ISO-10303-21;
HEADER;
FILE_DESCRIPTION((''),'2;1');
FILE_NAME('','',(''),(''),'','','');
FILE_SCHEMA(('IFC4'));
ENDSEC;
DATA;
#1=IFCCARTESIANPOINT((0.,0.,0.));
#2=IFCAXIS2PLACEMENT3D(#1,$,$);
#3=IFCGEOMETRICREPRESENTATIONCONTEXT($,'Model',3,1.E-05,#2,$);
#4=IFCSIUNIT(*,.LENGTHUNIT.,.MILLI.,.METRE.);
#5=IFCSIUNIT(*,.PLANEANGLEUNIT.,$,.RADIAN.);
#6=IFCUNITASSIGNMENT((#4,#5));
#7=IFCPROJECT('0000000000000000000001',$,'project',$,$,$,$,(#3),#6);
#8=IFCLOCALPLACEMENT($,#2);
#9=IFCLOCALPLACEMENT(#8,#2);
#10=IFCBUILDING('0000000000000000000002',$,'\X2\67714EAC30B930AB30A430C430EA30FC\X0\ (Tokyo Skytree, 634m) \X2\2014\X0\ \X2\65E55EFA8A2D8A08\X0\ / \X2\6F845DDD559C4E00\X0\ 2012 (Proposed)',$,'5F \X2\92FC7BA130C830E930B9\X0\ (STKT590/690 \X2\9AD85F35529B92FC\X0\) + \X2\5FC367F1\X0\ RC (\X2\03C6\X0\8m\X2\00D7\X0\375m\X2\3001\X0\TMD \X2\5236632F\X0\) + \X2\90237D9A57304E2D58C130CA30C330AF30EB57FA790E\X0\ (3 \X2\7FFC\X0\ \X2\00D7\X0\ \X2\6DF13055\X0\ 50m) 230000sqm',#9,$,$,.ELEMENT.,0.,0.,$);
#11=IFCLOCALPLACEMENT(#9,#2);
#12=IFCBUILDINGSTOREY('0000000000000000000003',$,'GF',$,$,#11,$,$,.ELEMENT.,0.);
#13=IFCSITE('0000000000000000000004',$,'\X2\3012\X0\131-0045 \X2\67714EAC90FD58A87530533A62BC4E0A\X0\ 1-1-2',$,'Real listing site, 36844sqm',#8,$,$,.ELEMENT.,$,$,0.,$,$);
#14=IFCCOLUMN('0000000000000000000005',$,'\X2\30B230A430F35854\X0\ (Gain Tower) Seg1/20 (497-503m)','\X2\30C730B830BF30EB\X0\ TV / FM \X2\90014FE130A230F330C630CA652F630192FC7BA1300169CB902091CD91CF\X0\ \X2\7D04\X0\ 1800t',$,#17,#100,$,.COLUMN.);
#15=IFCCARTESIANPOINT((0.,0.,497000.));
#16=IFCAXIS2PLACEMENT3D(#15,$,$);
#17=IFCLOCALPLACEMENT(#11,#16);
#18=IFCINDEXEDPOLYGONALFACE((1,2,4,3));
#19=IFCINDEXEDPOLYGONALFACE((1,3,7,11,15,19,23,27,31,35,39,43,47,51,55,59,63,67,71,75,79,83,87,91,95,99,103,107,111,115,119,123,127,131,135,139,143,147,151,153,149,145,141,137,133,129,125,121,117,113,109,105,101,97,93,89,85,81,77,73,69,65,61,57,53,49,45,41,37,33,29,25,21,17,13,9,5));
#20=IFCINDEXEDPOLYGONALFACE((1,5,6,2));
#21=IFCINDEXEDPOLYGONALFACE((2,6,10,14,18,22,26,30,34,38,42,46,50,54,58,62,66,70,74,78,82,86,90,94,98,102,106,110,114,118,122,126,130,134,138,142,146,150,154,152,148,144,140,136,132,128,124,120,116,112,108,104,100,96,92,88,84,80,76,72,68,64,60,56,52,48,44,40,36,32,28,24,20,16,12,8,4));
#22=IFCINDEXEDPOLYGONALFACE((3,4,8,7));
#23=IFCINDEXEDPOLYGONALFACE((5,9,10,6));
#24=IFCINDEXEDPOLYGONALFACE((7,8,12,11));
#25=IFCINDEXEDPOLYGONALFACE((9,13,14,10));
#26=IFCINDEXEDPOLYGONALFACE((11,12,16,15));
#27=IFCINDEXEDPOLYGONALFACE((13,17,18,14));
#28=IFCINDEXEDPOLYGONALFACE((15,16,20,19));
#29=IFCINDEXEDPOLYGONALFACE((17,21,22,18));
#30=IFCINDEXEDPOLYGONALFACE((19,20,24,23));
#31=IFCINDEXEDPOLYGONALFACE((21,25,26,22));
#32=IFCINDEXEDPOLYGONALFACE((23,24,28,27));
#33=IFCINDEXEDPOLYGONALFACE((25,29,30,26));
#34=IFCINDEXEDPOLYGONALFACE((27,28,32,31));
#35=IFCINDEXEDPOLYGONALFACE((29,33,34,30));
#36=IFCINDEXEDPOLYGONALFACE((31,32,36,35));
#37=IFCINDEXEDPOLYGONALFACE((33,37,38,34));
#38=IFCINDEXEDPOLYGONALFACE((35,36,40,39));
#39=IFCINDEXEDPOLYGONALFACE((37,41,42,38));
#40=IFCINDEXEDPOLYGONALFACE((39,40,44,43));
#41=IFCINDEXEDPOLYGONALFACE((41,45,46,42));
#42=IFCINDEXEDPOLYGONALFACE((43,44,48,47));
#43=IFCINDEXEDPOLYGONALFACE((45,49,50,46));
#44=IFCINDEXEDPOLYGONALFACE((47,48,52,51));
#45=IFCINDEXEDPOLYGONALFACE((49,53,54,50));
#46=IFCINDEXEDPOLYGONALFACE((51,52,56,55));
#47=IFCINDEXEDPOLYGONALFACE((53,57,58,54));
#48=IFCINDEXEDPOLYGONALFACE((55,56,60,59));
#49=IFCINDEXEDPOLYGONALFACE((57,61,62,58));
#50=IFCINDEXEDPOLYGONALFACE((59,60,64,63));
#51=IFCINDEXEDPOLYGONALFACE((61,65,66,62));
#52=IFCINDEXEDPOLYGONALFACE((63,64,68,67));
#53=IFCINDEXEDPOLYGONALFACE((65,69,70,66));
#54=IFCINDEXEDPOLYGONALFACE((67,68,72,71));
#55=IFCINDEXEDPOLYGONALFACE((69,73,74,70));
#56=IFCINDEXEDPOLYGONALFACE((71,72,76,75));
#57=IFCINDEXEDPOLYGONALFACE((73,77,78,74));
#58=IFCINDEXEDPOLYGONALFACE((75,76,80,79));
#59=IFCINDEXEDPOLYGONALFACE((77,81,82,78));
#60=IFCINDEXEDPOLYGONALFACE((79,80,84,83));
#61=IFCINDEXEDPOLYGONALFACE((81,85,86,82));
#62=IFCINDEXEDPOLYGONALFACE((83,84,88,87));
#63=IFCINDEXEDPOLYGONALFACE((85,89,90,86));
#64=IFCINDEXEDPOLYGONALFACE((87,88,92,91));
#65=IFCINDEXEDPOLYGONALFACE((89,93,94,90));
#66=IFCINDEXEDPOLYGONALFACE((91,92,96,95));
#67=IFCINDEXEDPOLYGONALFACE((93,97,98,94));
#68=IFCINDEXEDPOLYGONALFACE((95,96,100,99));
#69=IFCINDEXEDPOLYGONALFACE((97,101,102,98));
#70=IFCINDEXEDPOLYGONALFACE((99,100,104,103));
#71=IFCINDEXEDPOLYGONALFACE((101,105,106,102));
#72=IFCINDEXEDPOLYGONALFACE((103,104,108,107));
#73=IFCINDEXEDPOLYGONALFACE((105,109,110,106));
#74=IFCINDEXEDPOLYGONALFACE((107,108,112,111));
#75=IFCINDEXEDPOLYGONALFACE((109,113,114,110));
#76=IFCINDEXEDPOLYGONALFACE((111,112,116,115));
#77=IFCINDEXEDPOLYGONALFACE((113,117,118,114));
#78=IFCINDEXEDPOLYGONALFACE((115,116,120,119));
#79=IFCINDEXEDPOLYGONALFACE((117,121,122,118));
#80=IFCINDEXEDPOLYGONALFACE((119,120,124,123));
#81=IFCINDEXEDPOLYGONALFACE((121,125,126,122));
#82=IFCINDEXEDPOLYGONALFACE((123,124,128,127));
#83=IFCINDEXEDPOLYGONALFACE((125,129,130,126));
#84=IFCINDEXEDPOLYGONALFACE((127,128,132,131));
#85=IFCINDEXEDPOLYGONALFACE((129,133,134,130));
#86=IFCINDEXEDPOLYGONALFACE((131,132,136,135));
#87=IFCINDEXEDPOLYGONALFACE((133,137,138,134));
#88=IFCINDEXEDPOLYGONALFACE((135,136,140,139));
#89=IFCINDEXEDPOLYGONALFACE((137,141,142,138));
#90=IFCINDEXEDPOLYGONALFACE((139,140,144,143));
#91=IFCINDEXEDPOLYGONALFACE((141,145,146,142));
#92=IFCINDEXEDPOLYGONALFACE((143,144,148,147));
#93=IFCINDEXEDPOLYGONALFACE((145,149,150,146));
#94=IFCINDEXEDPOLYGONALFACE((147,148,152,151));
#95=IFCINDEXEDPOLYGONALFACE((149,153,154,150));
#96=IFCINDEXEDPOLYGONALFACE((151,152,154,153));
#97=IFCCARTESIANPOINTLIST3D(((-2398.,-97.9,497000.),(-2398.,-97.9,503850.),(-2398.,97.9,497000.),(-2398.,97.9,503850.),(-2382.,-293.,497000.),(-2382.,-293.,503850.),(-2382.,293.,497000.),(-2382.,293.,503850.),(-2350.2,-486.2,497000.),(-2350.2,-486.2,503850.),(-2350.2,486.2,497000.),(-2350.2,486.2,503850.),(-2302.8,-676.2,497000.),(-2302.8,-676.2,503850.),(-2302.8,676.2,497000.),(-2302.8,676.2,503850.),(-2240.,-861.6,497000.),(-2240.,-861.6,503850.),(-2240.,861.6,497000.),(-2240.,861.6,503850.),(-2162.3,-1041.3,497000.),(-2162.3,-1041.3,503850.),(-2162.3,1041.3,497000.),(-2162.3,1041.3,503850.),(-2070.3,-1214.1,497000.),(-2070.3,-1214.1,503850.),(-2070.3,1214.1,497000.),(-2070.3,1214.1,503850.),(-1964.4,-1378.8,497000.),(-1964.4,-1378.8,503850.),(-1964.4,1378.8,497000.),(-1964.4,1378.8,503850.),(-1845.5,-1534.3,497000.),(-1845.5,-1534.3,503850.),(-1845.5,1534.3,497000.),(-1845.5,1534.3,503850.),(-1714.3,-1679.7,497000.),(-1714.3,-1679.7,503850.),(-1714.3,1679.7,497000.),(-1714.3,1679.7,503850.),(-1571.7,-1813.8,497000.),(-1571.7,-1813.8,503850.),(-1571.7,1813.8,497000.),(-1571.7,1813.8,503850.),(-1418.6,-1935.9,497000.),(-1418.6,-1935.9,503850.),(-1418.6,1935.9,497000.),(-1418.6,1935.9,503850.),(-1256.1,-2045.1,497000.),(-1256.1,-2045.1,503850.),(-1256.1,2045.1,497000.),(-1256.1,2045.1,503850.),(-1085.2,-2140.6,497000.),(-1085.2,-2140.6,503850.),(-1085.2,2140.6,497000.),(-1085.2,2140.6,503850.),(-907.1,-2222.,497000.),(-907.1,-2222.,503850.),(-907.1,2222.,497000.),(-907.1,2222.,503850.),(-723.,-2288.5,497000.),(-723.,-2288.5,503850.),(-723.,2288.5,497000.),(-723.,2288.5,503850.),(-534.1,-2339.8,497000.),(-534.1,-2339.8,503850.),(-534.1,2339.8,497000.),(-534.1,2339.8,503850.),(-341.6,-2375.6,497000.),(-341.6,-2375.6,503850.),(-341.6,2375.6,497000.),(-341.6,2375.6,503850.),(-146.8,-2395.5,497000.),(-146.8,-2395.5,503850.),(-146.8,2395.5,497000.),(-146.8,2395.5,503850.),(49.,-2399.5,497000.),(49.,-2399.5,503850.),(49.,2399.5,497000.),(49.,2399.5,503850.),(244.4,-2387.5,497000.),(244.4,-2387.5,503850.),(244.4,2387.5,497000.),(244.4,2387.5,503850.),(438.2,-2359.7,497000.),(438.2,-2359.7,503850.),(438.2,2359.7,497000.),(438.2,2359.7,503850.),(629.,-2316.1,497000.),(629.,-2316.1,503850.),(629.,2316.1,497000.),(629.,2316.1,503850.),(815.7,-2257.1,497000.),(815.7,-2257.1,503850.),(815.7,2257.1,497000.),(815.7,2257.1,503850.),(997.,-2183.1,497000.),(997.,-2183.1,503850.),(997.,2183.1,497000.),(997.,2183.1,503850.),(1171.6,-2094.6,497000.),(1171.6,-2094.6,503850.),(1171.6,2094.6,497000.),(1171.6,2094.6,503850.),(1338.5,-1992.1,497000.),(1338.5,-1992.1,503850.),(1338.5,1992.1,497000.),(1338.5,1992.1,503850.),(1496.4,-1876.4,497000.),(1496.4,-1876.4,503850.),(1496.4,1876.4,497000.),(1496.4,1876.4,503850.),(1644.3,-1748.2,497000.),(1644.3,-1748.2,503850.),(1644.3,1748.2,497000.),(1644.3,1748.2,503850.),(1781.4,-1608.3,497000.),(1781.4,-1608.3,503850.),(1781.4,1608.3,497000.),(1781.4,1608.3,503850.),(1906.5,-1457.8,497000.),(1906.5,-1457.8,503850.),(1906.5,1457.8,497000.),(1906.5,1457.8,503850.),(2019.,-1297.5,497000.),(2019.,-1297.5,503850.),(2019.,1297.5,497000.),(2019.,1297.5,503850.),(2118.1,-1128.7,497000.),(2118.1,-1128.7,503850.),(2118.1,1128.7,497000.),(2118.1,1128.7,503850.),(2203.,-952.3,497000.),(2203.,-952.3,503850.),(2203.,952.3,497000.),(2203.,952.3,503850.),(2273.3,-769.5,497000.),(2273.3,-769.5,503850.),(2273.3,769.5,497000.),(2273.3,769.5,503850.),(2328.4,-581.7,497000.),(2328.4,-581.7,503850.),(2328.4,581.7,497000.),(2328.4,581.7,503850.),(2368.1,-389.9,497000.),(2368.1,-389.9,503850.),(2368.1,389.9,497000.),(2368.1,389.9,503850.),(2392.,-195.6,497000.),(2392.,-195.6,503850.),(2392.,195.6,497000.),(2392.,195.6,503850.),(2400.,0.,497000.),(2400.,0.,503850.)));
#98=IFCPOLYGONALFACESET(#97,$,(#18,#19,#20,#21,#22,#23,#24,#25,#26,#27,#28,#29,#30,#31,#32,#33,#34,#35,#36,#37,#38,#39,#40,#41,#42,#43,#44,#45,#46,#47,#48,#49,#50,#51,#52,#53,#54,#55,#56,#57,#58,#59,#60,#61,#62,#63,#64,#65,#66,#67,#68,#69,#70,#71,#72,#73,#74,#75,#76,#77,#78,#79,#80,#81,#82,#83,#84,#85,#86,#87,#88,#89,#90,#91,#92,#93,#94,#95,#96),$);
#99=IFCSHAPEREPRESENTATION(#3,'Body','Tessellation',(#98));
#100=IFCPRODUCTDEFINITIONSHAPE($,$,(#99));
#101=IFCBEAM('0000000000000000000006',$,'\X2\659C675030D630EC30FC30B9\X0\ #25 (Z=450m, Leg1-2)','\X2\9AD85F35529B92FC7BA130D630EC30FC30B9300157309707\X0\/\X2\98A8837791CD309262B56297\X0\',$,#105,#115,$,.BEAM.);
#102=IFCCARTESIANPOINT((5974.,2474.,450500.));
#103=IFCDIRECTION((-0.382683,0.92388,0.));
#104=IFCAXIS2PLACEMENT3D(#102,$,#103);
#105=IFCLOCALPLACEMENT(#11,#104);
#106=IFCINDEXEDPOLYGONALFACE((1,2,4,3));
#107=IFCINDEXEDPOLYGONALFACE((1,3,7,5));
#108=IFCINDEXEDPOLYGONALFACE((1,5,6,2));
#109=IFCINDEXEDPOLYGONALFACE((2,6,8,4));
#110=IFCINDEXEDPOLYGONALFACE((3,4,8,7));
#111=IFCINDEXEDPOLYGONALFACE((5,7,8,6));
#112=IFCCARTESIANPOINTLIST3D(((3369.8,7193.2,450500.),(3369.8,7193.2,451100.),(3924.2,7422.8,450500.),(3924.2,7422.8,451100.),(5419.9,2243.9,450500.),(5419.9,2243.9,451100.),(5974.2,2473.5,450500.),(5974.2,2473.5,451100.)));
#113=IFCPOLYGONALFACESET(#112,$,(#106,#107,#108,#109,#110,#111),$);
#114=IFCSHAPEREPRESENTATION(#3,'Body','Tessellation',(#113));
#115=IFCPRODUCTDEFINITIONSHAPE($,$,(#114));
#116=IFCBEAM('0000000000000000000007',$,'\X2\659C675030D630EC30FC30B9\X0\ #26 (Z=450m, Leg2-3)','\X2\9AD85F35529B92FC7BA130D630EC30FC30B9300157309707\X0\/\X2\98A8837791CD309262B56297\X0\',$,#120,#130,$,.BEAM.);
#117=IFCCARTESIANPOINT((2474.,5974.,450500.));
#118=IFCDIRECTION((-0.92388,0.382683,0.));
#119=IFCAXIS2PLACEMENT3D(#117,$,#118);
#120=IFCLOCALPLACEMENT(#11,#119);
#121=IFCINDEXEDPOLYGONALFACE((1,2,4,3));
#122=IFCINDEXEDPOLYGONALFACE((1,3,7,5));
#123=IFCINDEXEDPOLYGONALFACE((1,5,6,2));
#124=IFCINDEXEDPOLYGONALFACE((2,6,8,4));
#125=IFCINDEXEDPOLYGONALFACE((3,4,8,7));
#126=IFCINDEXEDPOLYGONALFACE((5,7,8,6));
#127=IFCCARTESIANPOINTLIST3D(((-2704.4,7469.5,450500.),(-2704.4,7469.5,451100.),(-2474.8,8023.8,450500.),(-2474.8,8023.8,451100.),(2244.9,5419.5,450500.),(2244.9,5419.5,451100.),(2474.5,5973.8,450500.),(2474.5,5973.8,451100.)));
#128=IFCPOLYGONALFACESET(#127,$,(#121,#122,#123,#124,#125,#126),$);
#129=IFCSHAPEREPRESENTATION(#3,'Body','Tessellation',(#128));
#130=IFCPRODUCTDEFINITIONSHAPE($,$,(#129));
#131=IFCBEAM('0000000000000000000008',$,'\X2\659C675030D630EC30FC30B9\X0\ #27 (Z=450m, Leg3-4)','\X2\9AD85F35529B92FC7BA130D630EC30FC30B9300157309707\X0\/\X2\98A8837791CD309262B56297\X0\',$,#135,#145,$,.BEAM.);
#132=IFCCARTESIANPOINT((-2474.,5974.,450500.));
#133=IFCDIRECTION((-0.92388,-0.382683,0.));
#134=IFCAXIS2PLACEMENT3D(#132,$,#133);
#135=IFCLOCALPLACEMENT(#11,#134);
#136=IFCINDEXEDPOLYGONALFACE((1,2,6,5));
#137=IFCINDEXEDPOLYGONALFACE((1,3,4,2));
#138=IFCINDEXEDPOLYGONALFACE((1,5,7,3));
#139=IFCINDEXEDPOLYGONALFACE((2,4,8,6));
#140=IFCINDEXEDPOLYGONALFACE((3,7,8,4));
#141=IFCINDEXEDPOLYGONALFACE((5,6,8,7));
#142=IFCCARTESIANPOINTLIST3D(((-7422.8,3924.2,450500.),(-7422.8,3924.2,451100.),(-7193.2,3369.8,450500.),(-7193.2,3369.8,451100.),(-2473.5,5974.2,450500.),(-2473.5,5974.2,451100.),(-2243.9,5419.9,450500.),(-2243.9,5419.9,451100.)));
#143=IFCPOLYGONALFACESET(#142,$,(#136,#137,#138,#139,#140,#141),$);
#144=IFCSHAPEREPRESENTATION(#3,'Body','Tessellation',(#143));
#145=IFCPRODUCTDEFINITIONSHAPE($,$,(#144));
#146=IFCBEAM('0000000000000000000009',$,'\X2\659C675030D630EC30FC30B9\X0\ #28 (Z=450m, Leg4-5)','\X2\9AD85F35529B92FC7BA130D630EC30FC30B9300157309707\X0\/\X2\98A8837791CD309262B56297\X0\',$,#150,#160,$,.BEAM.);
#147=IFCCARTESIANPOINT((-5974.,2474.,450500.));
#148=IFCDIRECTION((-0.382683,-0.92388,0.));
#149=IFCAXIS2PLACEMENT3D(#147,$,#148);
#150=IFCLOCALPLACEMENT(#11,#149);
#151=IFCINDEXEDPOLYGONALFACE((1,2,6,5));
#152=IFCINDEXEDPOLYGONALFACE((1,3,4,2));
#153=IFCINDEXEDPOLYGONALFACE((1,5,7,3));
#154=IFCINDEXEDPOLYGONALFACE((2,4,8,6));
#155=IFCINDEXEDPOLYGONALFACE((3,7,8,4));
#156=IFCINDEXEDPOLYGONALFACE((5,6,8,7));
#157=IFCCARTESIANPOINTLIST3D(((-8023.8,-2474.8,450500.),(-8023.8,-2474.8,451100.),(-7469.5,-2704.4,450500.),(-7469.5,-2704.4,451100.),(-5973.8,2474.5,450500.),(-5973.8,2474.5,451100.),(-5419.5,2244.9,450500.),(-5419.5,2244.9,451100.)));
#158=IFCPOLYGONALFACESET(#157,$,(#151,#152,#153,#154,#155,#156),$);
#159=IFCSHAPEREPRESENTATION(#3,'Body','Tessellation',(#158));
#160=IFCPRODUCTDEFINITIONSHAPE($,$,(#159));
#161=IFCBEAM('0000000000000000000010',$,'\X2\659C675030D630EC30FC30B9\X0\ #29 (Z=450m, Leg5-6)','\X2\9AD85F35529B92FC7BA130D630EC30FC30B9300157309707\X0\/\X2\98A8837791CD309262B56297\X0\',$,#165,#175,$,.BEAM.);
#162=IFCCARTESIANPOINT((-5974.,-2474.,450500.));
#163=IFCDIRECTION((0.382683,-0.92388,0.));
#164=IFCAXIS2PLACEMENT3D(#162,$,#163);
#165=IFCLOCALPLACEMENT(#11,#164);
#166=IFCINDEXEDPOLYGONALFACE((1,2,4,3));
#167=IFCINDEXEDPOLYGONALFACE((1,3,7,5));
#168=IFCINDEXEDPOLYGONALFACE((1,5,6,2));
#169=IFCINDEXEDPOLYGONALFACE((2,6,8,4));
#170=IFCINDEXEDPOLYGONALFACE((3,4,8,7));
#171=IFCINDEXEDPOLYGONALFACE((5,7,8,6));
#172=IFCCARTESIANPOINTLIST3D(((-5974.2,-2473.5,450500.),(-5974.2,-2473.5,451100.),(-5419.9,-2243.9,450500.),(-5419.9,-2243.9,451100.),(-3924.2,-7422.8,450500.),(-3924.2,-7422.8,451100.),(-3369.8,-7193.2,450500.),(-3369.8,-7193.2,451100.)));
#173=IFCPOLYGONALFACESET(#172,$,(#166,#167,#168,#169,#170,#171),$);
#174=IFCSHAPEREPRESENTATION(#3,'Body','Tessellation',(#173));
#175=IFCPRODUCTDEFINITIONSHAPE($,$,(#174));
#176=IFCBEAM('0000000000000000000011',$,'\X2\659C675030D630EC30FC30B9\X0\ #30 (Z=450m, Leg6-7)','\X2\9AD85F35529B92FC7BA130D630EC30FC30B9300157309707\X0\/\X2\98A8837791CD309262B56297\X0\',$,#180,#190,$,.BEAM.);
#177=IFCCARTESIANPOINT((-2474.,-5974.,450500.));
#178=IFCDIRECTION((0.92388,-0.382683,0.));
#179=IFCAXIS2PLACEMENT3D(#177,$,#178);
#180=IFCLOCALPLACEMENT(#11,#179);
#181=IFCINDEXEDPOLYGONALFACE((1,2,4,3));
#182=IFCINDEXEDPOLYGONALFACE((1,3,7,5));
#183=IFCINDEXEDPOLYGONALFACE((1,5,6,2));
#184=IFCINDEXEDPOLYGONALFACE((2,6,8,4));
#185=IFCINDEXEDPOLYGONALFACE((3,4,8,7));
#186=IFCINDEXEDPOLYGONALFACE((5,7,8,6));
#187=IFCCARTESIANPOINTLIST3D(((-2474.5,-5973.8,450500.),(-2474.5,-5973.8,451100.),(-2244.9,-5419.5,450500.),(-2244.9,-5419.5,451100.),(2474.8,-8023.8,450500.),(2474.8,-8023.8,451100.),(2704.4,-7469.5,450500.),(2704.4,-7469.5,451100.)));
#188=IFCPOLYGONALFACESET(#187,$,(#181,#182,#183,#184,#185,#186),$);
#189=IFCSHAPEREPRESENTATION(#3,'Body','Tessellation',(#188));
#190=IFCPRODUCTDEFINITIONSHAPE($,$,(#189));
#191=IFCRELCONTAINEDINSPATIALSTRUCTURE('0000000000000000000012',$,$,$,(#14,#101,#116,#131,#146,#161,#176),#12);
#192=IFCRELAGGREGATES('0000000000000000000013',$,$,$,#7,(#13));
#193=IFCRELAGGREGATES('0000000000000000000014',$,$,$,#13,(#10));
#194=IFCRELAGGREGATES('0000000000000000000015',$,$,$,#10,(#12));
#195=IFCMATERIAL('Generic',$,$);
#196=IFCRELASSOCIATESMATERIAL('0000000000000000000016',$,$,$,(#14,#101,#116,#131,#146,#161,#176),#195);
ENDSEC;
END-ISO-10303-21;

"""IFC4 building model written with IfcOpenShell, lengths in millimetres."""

from ifc_helpers import new_model, si_unit, frame, frame_2d, origin, origin_2d, place, context, project, spatial, rectangle, circle, extrude, material, element, save


model = new_model("IFC4")

# Units and contexts
model_context = context("Model", 3, precision=1e-05, world=origin())
ifc_project = project(units=[si_unit("LENGTHUNIT", "METRE", prefix="MILLI"), si_unit("PLANEANGLEUNIT", "RADIAN")], contexts=[model_context])

# Site, building, storey
site_placement = place(None, origin())
site = spatial("IfcSite", under=ifc_project, at=site_placement, Name="〒131-0045 東京都墨田区押上 1-1-2", ObjectType="Real listing site, 36844sqm", CompositionType="ELEMENT", RefElevation=0.0)
building_placement = place(site_placement, origin())
building = spatial("IfcBuilding", under=site, at=building_placement, Name="東京スカイツリー (Tokyo Skytree, 634m) — 日建設計 / 澄川喜一 2012 (Proposed)", ObjectType="5F 鋼管トラス (STKT590/690 高張力鋼) + 心柱 RC (φ8m×375m、TMD 制振) + 連続地中壁ナックル基礎 (3 翼 × 深さ 50m) 230000sqm", CompositionType="ELEMENT", ElevationOfRefHeight=0.0, ElevationOfTerrain=0.0)
storey_placement = place(building_placement, origin())
storey = spatial("IfcBuildingStorey", under=building, at=storey_placement, Name="GF", CompositionType="ELEMENT", Elevation=0.0)

# Column
ifc_material = material(Name="Generic")
column_1_placement = place(storey_placement, frame((0.0, 0.0, 497000.0)))
element("IfcColumn", 1, at=column_1_placement, inside=storey, material=ifc_material, Name="ゲイン塔 (Gain Tower) Seg1/20 (497-503m)", Description="デジタル TV / FM 送信アンテナ支持鋼管、構造重量 約 1800t", PredefinedType="COLUMN", context=model_context, shape_type="SweptSolid", body=[
    extrude(circle(Radius=2400.0, at=origin_2d()), frame((0.0, 0.0, 497000.0)), (0.0, 0.0, 1.0), 6850.0),
])

# Beams
beam_1_placement = place(storey_placement, frame((5974.0, 2474.0, 450500.0), x_axis=(-0.382683, 0.92388, 0.0)))
element("IfcBeam", 2, at=beam_1_placement, inside=storey, material=ifc_material, Name="斜材ブレース #25 (Z=450m, Leg1-2)", Description="高張力鋼管ブレース、地震/風荷重を抵抗", PredefinedType="BEAM", context=model_context, shape_type="SweptSolid", body=[
    extrude(rectangle(XDim=5357.0, YDim=600.0, at=frame_2d((2678.0, 300.0))), frame((5974.0, 2474.0, 450500.0), x_axis=(-0.382683, 0.92388, 0.0)), (0.0, 0.0, 1.0), 600.0),
])
beam_2_placement = place(storey_placement, frame((2474.0, 5974.0, 450500.0), x_axis=(-0.92388, 0.382683, 0.0)))
element("IfcBeam", 3, at=beam_2_placement, inside=storey, material=ifc_material, Name="斜材ブレース #26 (Z=450m, Leg2-3)", Description="高張力鋼管ブレース、地震/風荷重を抵抗", PredefinedType="BEAM", context=model_context, shape_type="SweptSolid", body=[
    extrude(rectangle(XDim=5357.0, YDim=600.0, at=frame_2d((2678.0, 300.0))), frame((2474.0, 5974.0, 450500.0), x_axis=(-0.92388, 0.382683, 0.0)), (0.0, 0.0, 1.0), 600.0),
])
beam_3_placement = place(storey_placement, frame((-2474.0, 5974.0, 450500.0), x_axis=(-0.92388, -0.382683, 0.0)))
element("IfcBeam", 4, at=beam_3_placement, inside=storey, material=ifc_material, Name="斜材ブレース #27 (Z=450m, Leg3-4)", Description="高張力鋼管ブレース、地震/風荷重を抵抗", PredefinedType="BEAM", context=model_context, shape_type="SweptSolid", body=[
    extrude(rectangle(XDim=5357.0, YDim=600.0, at=frame_2d((2678.0, 300.0))), frame((-2474.0, 5974.0, 450500.0), x_axis=(-0.92388, -0.382683, 0.0)), (0.0, 0.0, 1.0), 600.0),
])
beam_4_placement = place(storey_placement, frame((-5974.0, 2474.0, 450500.0), x_axis=(-0.382683, -0.92388, 0.0)))
element("IfcBeam", 5, at=beam_4_placement, inside=storey, material=ifc_material, Name="斜材ブレース #28 (Z=450m, Leg4-5)", Description="高張力鋼管ブレース、地震/風荷重を抵抗", PredefinedType="BEAM", context=model_context, shape_type="SweptSolid", body=[
    extrude(rectangle(XDim=5357.0, YDim=600.0, at=frame_2d((2678.0, 300.0))), frame((-5974.0, 2474.0, 450500.0), x_axis=(-0.382683, -0.92388, 0.0)), (0.0, 0.0, 1.0), 600.0),
])
beam_5_placement = place(storey_placement, frame((-5974.0, -2474.0, 450500.0), x_axis=(0.382683, -0.92388, 0.0)))
element("IfcBeam", 6, at=beam_5_placement, inside=storey, material=ifc_material, Name="斜材ブレース #29 (Z=450m, Leg5-6)", Description="高張力鋼管ブレース、地震/風荷重を抵抗", PredefinedType="BEAM", context=model_context, shape_type="SweptSolid", body=[
    extrude(rectangle(XDim=5357.0, YDim=600.0, at=frame_2d((2678.0, 300.0))), frame((-5974.0, -2474.0, 450500.0), x_axis=(0.382683, -0.92388, 0.0)), (0.0, 0.0, 1.0), 600.0),
])
beam_6_placement = place(storey_placement, frame((-2474.0, -5974.0, 450500.0), x_axis=(0.92388, -0.382683, 0.0)))
element("IfcBeam", 7, at=beam_6_placement, inside=storey, material=ifc_material, Name="斜材ブレース #30 (Z=450m, Leg6-7)", Description="高張力鋼管ブレース、地震/風荷重を抵抗", PredefinedType="BEAM", context=model_context, shape_type="SweptSolid", body=[
    extrude(rectangle(XDim=5357.0, YDim=600.0, at=frame_2d((2678.0, 300.0))), frame((-2474.0, -5974.0, 450500.0), x_axis=(0.92388, -0.382683, 0.0)), (0.0, 0.0, 1.0), 600.0),
])

save(model, "model.ifc")
